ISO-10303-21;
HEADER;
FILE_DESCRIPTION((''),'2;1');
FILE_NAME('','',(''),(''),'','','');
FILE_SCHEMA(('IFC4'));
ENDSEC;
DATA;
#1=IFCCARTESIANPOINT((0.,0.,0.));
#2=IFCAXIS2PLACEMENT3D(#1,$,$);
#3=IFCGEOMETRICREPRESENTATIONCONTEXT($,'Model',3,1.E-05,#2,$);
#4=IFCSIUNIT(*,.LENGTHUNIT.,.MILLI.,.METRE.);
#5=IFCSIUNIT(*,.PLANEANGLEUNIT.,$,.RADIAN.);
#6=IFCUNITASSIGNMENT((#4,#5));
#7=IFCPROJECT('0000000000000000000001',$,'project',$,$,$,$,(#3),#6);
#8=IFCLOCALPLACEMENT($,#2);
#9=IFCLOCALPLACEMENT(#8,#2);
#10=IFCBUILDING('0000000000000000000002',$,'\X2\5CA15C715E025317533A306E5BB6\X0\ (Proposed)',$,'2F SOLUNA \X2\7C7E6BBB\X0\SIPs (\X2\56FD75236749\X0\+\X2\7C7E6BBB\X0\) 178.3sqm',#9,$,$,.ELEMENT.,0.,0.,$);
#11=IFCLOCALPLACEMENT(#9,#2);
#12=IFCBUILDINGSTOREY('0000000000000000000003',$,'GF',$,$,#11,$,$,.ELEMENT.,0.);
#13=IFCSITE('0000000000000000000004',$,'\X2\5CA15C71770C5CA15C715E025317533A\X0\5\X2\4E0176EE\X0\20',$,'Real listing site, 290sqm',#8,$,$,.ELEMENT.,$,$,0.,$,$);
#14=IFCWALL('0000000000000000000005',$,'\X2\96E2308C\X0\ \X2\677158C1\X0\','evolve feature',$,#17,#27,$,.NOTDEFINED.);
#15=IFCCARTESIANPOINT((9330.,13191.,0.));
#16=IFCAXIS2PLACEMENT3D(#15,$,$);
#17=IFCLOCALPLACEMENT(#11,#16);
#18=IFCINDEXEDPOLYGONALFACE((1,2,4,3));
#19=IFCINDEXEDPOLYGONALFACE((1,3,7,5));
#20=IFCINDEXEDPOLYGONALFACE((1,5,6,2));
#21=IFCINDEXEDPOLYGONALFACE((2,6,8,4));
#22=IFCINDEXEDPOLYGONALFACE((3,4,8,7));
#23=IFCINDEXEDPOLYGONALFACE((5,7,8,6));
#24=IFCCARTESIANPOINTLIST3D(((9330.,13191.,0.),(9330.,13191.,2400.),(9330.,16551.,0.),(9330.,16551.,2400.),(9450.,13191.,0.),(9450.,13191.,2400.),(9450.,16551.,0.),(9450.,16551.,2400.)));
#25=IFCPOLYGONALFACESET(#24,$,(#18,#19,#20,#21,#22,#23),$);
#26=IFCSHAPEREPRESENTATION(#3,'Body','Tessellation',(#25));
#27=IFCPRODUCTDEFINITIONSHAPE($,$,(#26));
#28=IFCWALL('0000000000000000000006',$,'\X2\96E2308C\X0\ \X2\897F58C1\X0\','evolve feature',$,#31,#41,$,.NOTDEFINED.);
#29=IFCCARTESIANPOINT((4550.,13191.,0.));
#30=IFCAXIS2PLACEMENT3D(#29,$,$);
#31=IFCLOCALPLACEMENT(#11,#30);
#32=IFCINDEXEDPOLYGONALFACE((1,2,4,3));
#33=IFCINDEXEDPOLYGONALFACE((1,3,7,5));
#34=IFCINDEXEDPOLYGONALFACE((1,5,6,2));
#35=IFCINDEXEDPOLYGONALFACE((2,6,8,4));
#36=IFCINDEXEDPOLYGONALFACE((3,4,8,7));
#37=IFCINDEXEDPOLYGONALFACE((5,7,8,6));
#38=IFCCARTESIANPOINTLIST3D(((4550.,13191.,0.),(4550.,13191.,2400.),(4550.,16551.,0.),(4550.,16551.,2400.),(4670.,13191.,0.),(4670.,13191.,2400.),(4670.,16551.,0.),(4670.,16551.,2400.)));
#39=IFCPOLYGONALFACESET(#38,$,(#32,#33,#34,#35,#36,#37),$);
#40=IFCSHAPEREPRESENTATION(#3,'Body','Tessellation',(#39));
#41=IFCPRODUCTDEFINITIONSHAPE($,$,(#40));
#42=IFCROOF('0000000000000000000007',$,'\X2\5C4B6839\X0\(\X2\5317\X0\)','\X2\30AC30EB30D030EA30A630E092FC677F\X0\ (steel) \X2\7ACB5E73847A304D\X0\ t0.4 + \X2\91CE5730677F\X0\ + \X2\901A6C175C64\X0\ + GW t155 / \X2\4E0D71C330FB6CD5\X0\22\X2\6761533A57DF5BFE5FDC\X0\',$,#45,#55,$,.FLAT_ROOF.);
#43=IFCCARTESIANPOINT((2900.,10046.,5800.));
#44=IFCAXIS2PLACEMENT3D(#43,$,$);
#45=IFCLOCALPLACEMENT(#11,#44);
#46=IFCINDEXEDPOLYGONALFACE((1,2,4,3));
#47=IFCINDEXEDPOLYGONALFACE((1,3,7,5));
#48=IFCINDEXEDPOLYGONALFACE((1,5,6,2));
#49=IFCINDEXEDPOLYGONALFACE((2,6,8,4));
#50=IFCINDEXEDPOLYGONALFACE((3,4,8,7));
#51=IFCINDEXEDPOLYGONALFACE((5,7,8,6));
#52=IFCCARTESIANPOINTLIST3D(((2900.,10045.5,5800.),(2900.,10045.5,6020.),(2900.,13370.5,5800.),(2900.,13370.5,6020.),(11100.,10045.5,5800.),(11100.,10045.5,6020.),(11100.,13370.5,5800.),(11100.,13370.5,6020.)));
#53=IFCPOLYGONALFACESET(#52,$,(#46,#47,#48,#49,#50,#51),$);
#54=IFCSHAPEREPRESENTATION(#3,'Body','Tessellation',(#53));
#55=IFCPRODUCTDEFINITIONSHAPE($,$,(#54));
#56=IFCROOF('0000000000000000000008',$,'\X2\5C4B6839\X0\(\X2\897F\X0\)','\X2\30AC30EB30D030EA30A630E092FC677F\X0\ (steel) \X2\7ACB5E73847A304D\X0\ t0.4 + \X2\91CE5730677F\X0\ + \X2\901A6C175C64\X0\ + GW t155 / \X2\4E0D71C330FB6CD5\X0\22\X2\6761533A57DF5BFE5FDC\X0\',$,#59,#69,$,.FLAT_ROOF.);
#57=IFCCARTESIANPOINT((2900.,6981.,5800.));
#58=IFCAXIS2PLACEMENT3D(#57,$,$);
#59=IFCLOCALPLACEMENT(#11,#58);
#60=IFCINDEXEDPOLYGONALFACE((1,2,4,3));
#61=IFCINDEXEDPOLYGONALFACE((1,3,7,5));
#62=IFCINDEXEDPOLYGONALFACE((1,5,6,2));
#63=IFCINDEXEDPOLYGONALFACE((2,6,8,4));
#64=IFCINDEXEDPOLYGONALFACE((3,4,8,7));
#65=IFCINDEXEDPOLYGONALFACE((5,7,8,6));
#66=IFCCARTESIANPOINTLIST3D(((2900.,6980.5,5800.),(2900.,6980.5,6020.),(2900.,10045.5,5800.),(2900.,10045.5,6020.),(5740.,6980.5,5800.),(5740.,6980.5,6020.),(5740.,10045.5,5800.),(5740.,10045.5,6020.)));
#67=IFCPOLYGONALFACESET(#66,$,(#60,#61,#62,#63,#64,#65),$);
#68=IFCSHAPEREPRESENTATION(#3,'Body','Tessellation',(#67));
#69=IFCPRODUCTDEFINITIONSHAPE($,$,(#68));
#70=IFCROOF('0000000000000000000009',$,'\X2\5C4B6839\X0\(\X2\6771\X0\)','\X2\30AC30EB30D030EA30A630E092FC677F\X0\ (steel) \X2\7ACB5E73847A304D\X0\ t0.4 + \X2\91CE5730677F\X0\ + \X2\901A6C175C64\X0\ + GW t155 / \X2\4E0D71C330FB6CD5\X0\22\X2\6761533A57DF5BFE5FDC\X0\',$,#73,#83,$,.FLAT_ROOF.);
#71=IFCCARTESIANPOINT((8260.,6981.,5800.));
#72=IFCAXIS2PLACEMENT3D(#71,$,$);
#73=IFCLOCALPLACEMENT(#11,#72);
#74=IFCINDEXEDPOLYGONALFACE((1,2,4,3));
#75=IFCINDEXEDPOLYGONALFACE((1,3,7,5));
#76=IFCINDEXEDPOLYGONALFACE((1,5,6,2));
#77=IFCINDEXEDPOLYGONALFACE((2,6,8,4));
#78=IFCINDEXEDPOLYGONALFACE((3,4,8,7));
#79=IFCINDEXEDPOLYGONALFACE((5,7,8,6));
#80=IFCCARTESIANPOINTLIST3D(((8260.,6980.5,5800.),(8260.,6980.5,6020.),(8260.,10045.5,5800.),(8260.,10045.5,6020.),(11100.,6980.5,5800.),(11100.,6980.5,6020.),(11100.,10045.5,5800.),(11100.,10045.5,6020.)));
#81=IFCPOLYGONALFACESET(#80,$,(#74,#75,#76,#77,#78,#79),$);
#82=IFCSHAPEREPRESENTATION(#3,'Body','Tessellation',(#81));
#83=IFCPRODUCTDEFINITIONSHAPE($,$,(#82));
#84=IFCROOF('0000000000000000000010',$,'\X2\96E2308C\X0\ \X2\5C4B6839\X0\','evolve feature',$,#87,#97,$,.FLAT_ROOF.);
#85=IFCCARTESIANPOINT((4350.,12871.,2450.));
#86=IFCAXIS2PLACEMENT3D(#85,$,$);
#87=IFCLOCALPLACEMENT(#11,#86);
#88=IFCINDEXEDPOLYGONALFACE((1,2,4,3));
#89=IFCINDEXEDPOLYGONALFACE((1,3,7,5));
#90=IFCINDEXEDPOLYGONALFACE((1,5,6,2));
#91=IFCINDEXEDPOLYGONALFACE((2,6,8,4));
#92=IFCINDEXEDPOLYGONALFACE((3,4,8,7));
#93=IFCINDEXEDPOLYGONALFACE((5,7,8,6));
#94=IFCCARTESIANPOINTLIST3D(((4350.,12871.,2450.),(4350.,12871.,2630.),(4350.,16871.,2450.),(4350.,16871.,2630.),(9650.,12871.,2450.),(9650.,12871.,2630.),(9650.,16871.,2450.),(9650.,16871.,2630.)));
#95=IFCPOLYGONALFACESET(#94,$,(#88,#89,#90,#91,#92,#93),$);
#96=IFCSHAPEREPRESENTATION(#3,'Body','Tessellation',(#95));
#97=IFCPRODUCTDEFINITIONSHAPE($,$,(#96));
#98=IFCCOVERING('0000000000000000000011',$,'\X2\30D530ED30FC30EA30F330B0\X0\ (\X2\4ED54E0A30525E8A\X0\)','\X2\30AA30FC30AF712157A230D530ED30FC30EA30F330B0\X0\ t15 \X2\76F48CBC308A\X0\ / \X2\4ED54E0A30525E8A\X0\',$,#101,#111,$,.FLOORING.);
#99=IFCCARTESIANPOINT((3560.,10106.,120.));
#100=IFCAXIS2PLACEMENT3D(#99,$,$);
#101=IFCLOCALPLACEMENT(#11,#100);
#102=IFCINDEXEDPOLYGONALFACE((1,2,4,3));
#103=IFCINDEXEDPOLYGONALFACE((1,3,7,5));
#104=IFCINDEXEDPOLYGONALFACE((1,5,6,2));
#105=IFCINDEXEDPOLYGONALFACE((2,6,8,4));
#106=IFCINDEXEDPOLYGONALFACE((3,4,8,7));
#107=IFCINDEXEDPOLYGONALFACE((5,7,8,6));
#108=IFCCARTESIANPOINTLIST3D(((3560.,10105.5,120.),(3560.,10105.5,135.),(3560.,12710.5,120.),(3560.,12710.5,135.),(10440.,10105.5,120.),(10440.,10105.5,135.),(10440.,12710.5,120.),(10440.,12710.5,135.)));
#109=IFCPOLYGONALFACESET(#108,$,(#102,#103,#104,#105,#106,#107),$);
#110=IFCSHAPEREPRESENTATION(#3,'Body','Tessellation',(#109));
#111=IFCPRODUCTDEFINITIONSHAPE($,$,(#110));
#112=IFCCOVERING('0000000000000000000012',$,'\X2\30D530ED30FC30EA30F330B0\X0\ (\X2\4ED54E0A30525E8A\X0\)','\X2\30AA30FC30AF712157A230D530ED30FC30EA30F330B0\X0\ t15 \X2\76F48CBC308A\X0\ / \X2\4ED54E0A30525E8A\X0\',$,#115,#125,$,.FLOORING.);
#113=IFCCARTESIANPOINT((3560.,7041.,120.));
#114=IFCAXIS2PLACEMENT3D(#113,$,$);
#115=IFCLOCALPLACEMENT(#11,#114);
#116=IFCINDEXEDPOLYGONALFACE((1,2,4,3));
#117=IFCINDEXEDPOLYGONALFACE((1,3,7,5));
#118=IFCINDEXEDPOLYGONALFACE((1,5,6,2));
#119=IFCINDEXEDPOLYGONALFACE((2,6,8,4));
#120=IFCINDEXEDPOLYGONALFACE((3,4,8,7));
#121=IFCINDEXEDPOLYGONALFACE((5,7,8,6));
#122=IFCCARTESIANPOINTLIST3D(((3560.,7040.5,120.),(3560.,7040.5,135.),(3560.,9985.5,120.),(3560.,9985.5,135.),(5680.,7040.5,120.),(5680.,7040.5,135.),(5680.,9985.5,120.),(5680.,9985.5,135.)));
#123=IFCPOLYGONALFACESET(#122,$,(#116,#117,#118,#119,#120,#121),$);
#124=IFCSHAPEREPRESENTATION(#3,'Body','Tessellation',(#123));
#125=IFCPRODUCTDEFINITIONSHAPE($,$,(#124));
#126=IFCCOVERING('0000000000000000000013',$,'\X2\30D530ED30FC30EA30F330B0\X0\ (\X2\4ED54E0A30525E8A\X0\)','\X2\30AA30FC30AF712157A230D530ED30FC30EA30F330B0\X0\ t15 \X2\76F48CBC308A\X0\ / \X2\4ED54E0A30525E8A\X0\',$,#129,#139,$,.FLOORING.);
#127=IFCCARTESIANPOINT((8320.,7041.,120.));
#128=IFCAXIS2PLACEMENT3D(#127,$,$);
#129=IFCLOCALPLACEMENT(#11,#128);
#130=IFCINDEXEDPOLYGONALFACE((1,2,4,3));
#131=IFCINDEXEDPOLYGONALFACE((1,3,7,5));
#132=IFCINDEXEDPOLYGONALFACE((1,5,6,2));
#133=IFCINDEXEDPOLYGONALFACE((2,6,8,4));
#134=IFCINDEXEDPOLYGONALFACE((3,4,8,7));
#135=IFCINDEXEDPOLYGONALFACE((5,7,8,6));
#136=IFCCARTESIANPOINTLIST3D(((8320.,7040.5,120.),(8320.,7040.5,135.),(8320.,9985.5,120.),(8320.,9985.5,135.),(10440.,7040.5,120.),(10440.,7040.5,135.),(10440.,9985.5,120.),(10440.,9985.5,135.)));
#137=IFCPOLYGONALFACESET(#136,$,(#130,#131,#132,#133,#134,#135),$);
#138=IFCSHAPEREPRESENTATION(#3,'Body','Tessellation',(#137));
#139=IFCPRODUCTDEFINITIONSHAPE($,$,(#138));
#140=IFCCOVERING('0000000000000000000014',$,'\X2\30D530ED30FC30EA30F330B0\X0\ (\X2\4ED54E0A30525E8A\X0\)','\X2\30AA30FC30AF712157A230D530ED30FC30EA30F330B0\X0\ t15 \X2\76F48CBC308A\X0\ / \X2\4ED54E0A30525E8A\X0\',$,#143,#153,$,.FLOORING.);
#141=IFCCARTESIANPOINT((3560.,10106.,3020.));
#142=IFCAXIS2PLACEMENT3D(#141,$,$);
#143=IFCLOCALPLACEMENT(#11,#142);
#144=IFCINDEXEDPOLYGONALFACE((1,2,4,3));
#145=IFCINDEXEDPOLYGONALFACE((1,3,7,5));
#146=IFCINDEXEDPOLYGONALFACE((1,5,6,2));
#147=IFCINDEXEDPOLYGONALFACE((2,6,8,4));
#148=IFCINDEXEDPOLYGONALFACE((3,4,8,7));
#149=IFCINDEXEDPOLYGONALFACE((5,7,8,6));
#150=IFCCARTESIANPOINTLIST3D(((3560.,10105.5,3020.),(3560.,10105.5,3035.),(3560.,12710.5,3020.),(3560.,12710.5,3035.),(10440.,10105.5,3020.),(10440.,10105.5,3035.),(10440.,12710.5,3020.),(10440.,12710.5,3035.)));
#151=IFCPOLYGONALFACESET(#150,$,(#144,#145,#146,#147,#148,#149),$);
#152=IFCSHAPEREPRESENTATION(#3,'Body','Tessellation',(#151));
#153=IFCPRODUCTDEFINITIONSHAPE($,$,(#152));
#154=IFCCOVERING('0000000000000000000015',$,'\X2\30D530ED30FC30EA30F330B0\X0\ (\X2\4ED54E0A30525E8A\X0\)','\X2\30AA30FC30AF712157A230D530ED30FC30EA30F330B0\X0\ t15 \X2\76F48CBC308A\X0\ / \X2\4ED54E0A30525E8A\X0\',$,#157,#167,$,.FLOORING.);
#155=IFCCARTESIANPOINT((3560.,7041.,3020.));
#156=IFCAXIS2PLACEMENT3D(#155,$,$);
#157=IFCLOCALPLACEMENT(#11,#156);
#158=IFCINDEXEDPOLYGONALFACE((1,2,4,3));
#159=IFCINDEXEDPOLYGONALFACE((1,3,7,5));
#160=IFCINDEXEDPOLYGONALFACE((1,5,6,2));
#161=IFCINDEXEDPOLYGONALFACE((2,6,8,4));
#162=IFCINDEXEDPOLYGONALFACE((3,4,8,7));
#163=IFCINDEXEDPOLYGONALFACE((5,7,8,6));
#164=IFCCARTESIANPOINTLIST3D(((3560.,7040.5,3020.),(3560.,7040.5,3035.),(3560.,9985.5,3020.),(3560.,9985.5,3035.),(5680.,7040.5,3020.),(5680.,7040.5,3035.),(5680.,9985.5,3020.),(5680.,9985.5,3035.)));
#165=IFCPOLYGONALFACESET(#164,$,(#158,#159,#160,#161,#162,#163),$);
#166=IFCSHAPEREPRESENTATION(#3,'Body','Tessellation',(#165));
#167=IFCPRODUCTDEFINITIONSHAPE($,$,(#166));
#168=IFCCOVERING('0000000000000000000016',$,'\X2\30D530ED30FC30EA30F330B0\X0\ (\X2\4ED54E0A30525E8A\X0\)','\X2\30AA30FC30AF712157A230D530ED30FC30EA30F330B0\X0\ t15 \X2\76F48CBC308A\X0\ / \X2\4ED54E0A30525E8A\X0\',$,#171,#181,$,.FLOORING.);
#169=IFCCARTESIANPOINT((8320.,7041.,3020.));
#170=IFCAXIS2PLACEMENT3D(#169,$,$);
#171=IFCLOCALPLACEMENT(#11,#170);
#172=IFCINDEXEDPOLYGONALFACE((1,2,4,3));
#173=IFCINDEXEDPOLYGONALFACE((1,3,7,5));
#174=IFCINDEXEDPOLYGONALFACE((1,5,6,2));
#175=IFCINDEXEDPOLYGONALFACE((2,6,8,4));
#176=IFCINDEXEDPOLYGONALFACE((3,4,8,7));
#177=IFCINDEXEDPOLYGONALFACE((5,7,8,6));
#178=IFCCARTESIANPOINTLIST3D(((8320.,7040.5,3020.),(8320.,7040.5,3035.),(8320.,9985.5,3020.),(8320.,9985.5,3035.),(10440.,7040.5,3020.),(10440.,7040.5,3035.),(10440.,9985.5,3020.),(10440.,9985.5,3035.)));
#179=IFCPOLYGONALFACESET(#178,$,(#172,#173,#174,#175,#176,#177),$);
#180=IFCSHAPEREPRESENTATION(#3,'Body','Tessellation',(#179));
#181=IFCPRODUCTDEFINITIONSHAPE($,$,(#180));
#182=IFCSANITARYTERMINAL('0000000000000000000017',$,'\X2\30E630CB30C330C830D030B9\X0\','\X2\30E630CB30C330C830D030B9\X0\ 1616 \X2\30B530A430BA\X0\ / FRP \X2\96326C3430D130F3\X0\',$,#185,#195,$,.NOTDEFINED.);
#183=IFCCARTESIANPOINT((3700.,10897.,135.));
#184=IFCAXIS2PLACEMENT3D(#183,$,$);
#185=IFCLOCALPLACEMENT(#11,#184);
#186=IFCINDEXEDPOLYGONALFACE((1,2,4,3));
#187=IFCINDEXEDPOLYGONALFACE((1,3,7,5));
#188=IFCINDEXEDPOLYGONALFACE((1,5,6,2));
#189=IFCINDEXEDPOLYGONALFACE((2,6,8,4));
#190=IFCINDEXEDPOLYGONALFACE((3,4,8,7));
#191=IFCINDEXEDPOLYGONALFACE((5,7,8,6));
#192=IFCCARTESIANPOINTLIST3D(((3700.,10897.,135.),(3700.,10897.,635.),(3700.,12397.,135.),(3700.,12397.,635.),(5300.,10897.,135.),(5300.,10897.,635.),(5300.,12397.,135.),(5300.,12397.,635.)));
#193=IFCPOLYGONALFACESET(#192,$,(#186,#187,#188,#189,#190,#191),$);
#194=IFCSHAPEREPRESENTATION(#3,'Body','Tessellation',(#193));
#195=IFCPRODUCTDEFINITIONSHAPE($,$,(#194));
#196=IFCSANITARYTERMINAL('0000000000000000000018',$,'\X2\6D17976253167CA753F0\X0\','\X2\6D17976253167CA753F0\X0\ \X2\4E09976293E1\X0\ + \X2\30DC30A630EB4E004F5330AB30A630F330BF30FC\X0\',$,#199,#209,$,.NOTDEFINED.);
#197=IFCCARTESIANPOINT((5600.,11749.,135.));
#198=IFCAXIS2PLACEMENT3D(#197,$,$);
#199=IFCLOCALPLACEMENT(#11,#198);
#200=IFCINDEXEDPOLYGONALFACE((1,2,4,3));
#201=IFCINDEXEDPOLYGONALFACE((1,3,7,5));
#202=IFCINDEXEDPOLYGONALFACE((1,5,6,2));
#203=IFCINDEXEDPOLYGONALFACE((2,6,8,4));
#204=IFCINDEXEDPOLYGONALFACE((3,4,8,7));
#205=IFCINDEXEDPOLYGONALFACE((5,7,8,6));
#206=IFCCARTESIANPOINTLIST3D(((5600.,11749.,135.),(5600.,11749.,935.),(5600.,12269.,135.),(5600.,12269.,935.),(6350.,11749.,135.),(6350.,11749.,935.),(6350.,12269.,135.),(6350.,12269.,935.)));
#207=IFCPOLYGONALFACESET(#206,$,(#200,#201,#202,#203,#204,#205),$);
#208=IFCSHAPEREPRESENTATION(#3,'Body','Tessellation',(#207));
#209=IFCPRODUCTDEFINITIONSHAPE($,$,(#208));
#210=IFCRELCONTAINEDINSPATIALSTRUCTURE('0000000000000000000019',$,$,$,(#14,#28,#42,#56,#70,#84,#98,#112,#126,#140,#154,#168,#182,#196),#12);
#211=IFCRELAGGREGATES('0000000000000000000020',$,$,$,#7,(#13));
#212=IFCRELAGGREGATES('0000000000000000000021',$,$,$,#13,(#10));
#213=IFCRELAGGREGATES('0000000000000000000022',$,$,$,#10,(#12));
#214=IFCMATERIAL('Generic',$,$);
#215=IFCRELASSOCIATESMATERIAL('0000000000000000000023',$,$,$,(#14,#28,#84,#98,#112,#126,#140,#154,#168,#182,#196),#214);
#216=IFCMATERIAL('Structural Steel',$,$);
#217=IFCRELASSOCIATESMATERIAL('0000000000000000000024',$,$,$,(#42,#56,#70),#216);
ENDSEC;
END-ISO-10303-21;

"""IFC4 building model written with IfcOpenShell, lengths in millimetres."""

from ifc_helpers import new_model, si_unit, frame, frame_2d, origin, place, context, project, spatial, rectangle, extrude, material, element, save


model = new_model("IFC4")

# Units and contexts
model_context = context("Model", 3, precision=1e-05, world=origin())
ifc_project = project(units=[si_unit("LENGTHUNIT", "METRE", prefix="MILLI"), si_unit("PLANEANGLEUNIT", "RADIAN")], contexts=[model_context])

# Site, building, storey
site_placement = place(None, origin())
site = spatial("IfcSite", under=ifc_project, at=site_placement, Name="岡山県岡山市北区5丁目20", ObjectType="Real listing site, 290sqm", CompositionType="ELEMENT", RefElevation=0.0)
building_placement = place(site_placement, origin())
building = spatial("IfcBuilding", under=site, at=building_placement, Name="岡山市北区の家 (Proposed)", ObjectType="2F SOLUNA 籾殻SIPs (国産杉+籾殻) 178.3sqm", CompositionType="ELEMENT", ElevationOfRefHeight=0.0, ElevationOfTerrain=0.0)
storey_placement = place(building_placement, origin())
storey = spatial("IfcBuildingStorey", under=building, at=storey_placement, Name="GF", CompositionType="ELEMENT", Elevation=0.0)

# Shared definitions
ifc_material_1 = material(Name="Generic")

# Walls
wall_1_placement = place(storey_placement, frame((9330.0, 13191.0, 0.0)))
element("IfcWall", 1, at=wall_1_placement, inside=storey, material=ifc_material_1, Name="離れ 東壁", Description="evolve feature", PredefinedType="NOTDEFINED", context=model_context, shape_type="SweptSolid", body=[
    extrude(rectangle(XDim=120.0, YDim=3360.0, at=frame_2d((60.0, 1680.0))), frame((9330.0, 13191.0, 0.0)), (0.0, 0.0, 1.0), 2400.0),
])
wall_2_placement = place(storey_placement, frame((4550.0, 13191.0, 0.0)))
element("IfcWall", 2, at=wall_2_placement, inside=storey, material=ifc_material_1, Name="離れ 西壁", Description="evolve feature", PredefinedType="NOTDEFINED", context=model_context, shape_type="SweptSolid", body=[
    extrude(rectangle(XDim=120.0, YDim=3360.0, at=frame_2d((60.0, 1680.0))), frame((4550.0, 13191.0, 0.0)), (0.0, 0.0, 1.0), 2400.0),
])

# Roofs
ifc_material_2 = material(Name="Structural Steel")
for number, where, name in (
    (3, (2900.0, 10046.0, 5800.0), "屋根(北)"),
):
    element("IfcRoof", number, at=place(storey_placement, frame(where)), inside=storey, material=ifc_material_2, Name=name, Description="ガルバリウム鋼板 (steel) 立平葺き t0.4 + 野地板 + 通気層 + GW t155 / 不燃・法22条区域対応", PredefinedType="FLAT_ROOF", context=model_context, shape_type="SweptSolid", body=[
        extrude(rectangle(XDim=8200.0, YDim=3325.0, at=frame_2d((4100.0, 1662.0))), frame((2900.0, 10046.0, 5800.0)), (0.0, 0.0, 1.0), 220.0),
    ])
roof_1_placement = place(storey_placement, frame((2900.0, 6981.0, 5800.0)))
element("IfcRoof", 4, at=roof_1_placement, inside=storey, material=ifc_material_2, Name="屋根(西)", Description="ガルバリウム鋼板 (steel) 立平葺き t0.4 + 野地板 + 通気層 + GW t155 / 不燃・法22条区域対応", PredefinedType="FLAT_ROOF", context=model_context, shape_type="SweptSolid", body=[
    extrude(rectangle(XDim=2840.0, YDim=3065.0, at=frame_2d((1420.0, 1532.0))), frame((2900.0, 6981.0, 5800.0)), (0.0, 0.0, 1.0), 220.0),
])
roof_2_placement = place(storey_placement, frame((8260.0, 6981.0, 5800.0)))
element("IfcRoof", 5, at=roof_2_placement, inside=storey, material=ifc_material_2, Name="屋根(東)", Description="ガルバリウム鋼板 (steel) 立平葺き t0.4 + 野地板 + 通気層 + GW t155 / 不燃・法22条区域対応", PredefinedType="FLAT_ROOF", context=model_context, shape_type="SweptSolid", body=[
    extrude(rectangle(XDim=2840.0, YDim=3065.0, at=frame_2d((1420.0, 1532.0))), frame((8260.0, 6981.0, 5800.0)), (0.0, 0.0, 1.0), 220.0),
])
roof_3_placement = place(storey_placement, frame((4350.0, 12871.0, 2450.0)))
element("IfcRoof", 6, at=roof_3_placement, inside=storey, material=ifc_material_1, Name="離れ 屋根", Description="evolve feature", PredefinedType="FLAT_ROOF", context=model_context, shape_type="SweptSolid", body=[
    extrude(rectangle(XDim=5300.0, YDim=4000.0, at=frame_2d((2650.0, 2000.0))), frame((4350.0, 12871.0, 2450.0)), (0.0, 0.0, 1.0), 180.0),
])

# Coverings
covering_1_placement = place(storey_placement, frame((3560.0, 10106.0, 120.0)))
element("IfcCovering", 7, at=covering_1_placement, inside=storey, material=ifc_material_1, Name="フローリング (仕上げ床)", Description="オーク無垢フローリング t15 直貼り / 仕上げ床", PredefinedType="FLOORING", context=model_context, shape_type="SweptSolid", body=[
    extrude(rectangle(XDim=6880.0, YDim=2605.0, at=frame_2d((3440.0, 1302.0))), frame((3560.0, 10106.0, 120.0)), (0.0, 0.0, 1.0), 15.0),
])
covering_2_placement = place(storey_placement, frame((3560.0, 7041.0, 120.0)))
element("IfcCovering", 8, at=covering_2_placement, inside=storey, material=ifc_material_1, Name="フローリング (仕上げ床)", Description="オーク無垢フローリング t15 直貼り / 仕上げ床", PredefinedType="FLOORING", context=model_context, shape_type="SweptSolid", body=[
    extrude(rectangle(XDim=2120.0, YDim=2945.0, at=frame_2d((1060.0, 1472.0))), frame((3560.0, 7041.0, 120.0)), (0.0, 0.0, 1.0), 15.0),
])
covering_3_placement = place(storey_placement, frame((8320.0, 7041.0, 120.0)))
element("IfcCovering", 9, at=covering_3_placement, inside=storey, material=ifc_material_1, Name="フローリング (仕上げ床)", Description="オーク無垢フローリング t15 直貼り / 仕上げ床", PredefinedType="FLOORING", context=model_context, shape_type="SweptSolid", body=[
    extrude(rectangle(XDim=2120.0, YDim=2945.0, at=frame_2d((1060.0, 1472.0))), frame((8320.0, 7041.0, 120.0)), (0.0, 0.0, 1.0), 15.0),
])
covering_4_placement = place(storey_placement, frame((3560.0, 10106.0, 3020.0)))
element("IfcCovering", 10, at=covering_4_placement, inside=storey, material=ifc_material_1, Name="フローリング (仕上げ床)", Description="オーク無垢フローリング t15 直貼り / 仕上げ床", PredefinedType="FLOORING", context=model_context, shape_type="SweptSolid", body=[
    extrude(rectangle(XDim=6880.0, YDim=2605.0, at=frame_2d((3440.0, 1302.0))), frame((3560.0, 10106.0, 3020.0)), (0.0, 0.0, 1.0), 15.0),
])
covering_5_placement = place(storey_placement, frame((3560.0, 7041.0, 3020.0)))
element("IfcCovering", 11, at=covering_5_placement, inside=storey, material=ifc_material_1, Name="フローリング (仕上げ床)", Description="オーク無垢フローリング t15 直貼り / 仕上げ床", PredefinedType="FLOORING", context=model_context, shape_type="SweptSolid", body=[
    extrude(rectangle(XDim=2120.0, YDim=2945.0, at=frame_2d((1060.0, 1472.0))), frame((3560.0, 7041.0, 3020.0)), (0.0, 0.0, 1.0), 15.0),
])
covering_6_placement = place(storey_placement, frame((8320.0, 7041.0, 3020.0)))
element("IfcCovering", 12, at=covering_6_placement, inside=storey, material=ifc_material_1, Name="フローリング (仕上げ床)", Description="オーク無垢フローリング t15 直貼り / 仕上げ床", PredefinedType="FLOORING", context=model_context, shape_type="SweptSolid", body=[
    extrude(rectangle(XDim=2120.0, YDim=2945.0, at=frame_2d((1060.0, 1472.0))), frame((8320.0, 7041.0, 3020.0)), (0.0, 0.0, 1.0), 15.0),
])

# Sanitary terminals
sanitary_terminal_1_placement = place(storey_placement, frame((3700.0, 10897.0, 135.0)))
element("IfcSanitaryTerminal", 13, at=sanitary_terminal_1_placement, inside=storey, material=ifc_material_1, Name="ユニットバス", Description="ユニットバス 1616 サイズ / FRP 防水パン", PredefinedType="NOTDEFINED", context=model_context, shape_type="SweptSolid", body=[
    extrude(rectangle(XDim=1600.0, YDim=1500.0, at=frame_2d((800.0, 750.0))), frame((3700.0, 10897.0, 135.0)), (0.0, 0.0, 1.0), 500.0),
])
sanitary_terminal_2_placement = place(storey_placement, frame((5600.0, 11749.0, 135.0)))
element("IfcSanitaryTerminal", 14, at=sanitary_terminal_2_placement, inside=storey, material=ifc_material_1, Name="洗面化粧台", Description="洗面化粧台 三面鏡 + ボウル一体カウンター", PredefinedType="NOTDEFINED", context=model_context, shape_type="SweptSolid", body=[
    extrude(rectangle(XDim=750.0, YDim=520.0, at=frame_2d((375.0, 260.0))), frame((5600.0, 11749.0, 135.0)), (0.0, 0.0, 1.0), 800.0),
])

save(model, "model.ifc")
